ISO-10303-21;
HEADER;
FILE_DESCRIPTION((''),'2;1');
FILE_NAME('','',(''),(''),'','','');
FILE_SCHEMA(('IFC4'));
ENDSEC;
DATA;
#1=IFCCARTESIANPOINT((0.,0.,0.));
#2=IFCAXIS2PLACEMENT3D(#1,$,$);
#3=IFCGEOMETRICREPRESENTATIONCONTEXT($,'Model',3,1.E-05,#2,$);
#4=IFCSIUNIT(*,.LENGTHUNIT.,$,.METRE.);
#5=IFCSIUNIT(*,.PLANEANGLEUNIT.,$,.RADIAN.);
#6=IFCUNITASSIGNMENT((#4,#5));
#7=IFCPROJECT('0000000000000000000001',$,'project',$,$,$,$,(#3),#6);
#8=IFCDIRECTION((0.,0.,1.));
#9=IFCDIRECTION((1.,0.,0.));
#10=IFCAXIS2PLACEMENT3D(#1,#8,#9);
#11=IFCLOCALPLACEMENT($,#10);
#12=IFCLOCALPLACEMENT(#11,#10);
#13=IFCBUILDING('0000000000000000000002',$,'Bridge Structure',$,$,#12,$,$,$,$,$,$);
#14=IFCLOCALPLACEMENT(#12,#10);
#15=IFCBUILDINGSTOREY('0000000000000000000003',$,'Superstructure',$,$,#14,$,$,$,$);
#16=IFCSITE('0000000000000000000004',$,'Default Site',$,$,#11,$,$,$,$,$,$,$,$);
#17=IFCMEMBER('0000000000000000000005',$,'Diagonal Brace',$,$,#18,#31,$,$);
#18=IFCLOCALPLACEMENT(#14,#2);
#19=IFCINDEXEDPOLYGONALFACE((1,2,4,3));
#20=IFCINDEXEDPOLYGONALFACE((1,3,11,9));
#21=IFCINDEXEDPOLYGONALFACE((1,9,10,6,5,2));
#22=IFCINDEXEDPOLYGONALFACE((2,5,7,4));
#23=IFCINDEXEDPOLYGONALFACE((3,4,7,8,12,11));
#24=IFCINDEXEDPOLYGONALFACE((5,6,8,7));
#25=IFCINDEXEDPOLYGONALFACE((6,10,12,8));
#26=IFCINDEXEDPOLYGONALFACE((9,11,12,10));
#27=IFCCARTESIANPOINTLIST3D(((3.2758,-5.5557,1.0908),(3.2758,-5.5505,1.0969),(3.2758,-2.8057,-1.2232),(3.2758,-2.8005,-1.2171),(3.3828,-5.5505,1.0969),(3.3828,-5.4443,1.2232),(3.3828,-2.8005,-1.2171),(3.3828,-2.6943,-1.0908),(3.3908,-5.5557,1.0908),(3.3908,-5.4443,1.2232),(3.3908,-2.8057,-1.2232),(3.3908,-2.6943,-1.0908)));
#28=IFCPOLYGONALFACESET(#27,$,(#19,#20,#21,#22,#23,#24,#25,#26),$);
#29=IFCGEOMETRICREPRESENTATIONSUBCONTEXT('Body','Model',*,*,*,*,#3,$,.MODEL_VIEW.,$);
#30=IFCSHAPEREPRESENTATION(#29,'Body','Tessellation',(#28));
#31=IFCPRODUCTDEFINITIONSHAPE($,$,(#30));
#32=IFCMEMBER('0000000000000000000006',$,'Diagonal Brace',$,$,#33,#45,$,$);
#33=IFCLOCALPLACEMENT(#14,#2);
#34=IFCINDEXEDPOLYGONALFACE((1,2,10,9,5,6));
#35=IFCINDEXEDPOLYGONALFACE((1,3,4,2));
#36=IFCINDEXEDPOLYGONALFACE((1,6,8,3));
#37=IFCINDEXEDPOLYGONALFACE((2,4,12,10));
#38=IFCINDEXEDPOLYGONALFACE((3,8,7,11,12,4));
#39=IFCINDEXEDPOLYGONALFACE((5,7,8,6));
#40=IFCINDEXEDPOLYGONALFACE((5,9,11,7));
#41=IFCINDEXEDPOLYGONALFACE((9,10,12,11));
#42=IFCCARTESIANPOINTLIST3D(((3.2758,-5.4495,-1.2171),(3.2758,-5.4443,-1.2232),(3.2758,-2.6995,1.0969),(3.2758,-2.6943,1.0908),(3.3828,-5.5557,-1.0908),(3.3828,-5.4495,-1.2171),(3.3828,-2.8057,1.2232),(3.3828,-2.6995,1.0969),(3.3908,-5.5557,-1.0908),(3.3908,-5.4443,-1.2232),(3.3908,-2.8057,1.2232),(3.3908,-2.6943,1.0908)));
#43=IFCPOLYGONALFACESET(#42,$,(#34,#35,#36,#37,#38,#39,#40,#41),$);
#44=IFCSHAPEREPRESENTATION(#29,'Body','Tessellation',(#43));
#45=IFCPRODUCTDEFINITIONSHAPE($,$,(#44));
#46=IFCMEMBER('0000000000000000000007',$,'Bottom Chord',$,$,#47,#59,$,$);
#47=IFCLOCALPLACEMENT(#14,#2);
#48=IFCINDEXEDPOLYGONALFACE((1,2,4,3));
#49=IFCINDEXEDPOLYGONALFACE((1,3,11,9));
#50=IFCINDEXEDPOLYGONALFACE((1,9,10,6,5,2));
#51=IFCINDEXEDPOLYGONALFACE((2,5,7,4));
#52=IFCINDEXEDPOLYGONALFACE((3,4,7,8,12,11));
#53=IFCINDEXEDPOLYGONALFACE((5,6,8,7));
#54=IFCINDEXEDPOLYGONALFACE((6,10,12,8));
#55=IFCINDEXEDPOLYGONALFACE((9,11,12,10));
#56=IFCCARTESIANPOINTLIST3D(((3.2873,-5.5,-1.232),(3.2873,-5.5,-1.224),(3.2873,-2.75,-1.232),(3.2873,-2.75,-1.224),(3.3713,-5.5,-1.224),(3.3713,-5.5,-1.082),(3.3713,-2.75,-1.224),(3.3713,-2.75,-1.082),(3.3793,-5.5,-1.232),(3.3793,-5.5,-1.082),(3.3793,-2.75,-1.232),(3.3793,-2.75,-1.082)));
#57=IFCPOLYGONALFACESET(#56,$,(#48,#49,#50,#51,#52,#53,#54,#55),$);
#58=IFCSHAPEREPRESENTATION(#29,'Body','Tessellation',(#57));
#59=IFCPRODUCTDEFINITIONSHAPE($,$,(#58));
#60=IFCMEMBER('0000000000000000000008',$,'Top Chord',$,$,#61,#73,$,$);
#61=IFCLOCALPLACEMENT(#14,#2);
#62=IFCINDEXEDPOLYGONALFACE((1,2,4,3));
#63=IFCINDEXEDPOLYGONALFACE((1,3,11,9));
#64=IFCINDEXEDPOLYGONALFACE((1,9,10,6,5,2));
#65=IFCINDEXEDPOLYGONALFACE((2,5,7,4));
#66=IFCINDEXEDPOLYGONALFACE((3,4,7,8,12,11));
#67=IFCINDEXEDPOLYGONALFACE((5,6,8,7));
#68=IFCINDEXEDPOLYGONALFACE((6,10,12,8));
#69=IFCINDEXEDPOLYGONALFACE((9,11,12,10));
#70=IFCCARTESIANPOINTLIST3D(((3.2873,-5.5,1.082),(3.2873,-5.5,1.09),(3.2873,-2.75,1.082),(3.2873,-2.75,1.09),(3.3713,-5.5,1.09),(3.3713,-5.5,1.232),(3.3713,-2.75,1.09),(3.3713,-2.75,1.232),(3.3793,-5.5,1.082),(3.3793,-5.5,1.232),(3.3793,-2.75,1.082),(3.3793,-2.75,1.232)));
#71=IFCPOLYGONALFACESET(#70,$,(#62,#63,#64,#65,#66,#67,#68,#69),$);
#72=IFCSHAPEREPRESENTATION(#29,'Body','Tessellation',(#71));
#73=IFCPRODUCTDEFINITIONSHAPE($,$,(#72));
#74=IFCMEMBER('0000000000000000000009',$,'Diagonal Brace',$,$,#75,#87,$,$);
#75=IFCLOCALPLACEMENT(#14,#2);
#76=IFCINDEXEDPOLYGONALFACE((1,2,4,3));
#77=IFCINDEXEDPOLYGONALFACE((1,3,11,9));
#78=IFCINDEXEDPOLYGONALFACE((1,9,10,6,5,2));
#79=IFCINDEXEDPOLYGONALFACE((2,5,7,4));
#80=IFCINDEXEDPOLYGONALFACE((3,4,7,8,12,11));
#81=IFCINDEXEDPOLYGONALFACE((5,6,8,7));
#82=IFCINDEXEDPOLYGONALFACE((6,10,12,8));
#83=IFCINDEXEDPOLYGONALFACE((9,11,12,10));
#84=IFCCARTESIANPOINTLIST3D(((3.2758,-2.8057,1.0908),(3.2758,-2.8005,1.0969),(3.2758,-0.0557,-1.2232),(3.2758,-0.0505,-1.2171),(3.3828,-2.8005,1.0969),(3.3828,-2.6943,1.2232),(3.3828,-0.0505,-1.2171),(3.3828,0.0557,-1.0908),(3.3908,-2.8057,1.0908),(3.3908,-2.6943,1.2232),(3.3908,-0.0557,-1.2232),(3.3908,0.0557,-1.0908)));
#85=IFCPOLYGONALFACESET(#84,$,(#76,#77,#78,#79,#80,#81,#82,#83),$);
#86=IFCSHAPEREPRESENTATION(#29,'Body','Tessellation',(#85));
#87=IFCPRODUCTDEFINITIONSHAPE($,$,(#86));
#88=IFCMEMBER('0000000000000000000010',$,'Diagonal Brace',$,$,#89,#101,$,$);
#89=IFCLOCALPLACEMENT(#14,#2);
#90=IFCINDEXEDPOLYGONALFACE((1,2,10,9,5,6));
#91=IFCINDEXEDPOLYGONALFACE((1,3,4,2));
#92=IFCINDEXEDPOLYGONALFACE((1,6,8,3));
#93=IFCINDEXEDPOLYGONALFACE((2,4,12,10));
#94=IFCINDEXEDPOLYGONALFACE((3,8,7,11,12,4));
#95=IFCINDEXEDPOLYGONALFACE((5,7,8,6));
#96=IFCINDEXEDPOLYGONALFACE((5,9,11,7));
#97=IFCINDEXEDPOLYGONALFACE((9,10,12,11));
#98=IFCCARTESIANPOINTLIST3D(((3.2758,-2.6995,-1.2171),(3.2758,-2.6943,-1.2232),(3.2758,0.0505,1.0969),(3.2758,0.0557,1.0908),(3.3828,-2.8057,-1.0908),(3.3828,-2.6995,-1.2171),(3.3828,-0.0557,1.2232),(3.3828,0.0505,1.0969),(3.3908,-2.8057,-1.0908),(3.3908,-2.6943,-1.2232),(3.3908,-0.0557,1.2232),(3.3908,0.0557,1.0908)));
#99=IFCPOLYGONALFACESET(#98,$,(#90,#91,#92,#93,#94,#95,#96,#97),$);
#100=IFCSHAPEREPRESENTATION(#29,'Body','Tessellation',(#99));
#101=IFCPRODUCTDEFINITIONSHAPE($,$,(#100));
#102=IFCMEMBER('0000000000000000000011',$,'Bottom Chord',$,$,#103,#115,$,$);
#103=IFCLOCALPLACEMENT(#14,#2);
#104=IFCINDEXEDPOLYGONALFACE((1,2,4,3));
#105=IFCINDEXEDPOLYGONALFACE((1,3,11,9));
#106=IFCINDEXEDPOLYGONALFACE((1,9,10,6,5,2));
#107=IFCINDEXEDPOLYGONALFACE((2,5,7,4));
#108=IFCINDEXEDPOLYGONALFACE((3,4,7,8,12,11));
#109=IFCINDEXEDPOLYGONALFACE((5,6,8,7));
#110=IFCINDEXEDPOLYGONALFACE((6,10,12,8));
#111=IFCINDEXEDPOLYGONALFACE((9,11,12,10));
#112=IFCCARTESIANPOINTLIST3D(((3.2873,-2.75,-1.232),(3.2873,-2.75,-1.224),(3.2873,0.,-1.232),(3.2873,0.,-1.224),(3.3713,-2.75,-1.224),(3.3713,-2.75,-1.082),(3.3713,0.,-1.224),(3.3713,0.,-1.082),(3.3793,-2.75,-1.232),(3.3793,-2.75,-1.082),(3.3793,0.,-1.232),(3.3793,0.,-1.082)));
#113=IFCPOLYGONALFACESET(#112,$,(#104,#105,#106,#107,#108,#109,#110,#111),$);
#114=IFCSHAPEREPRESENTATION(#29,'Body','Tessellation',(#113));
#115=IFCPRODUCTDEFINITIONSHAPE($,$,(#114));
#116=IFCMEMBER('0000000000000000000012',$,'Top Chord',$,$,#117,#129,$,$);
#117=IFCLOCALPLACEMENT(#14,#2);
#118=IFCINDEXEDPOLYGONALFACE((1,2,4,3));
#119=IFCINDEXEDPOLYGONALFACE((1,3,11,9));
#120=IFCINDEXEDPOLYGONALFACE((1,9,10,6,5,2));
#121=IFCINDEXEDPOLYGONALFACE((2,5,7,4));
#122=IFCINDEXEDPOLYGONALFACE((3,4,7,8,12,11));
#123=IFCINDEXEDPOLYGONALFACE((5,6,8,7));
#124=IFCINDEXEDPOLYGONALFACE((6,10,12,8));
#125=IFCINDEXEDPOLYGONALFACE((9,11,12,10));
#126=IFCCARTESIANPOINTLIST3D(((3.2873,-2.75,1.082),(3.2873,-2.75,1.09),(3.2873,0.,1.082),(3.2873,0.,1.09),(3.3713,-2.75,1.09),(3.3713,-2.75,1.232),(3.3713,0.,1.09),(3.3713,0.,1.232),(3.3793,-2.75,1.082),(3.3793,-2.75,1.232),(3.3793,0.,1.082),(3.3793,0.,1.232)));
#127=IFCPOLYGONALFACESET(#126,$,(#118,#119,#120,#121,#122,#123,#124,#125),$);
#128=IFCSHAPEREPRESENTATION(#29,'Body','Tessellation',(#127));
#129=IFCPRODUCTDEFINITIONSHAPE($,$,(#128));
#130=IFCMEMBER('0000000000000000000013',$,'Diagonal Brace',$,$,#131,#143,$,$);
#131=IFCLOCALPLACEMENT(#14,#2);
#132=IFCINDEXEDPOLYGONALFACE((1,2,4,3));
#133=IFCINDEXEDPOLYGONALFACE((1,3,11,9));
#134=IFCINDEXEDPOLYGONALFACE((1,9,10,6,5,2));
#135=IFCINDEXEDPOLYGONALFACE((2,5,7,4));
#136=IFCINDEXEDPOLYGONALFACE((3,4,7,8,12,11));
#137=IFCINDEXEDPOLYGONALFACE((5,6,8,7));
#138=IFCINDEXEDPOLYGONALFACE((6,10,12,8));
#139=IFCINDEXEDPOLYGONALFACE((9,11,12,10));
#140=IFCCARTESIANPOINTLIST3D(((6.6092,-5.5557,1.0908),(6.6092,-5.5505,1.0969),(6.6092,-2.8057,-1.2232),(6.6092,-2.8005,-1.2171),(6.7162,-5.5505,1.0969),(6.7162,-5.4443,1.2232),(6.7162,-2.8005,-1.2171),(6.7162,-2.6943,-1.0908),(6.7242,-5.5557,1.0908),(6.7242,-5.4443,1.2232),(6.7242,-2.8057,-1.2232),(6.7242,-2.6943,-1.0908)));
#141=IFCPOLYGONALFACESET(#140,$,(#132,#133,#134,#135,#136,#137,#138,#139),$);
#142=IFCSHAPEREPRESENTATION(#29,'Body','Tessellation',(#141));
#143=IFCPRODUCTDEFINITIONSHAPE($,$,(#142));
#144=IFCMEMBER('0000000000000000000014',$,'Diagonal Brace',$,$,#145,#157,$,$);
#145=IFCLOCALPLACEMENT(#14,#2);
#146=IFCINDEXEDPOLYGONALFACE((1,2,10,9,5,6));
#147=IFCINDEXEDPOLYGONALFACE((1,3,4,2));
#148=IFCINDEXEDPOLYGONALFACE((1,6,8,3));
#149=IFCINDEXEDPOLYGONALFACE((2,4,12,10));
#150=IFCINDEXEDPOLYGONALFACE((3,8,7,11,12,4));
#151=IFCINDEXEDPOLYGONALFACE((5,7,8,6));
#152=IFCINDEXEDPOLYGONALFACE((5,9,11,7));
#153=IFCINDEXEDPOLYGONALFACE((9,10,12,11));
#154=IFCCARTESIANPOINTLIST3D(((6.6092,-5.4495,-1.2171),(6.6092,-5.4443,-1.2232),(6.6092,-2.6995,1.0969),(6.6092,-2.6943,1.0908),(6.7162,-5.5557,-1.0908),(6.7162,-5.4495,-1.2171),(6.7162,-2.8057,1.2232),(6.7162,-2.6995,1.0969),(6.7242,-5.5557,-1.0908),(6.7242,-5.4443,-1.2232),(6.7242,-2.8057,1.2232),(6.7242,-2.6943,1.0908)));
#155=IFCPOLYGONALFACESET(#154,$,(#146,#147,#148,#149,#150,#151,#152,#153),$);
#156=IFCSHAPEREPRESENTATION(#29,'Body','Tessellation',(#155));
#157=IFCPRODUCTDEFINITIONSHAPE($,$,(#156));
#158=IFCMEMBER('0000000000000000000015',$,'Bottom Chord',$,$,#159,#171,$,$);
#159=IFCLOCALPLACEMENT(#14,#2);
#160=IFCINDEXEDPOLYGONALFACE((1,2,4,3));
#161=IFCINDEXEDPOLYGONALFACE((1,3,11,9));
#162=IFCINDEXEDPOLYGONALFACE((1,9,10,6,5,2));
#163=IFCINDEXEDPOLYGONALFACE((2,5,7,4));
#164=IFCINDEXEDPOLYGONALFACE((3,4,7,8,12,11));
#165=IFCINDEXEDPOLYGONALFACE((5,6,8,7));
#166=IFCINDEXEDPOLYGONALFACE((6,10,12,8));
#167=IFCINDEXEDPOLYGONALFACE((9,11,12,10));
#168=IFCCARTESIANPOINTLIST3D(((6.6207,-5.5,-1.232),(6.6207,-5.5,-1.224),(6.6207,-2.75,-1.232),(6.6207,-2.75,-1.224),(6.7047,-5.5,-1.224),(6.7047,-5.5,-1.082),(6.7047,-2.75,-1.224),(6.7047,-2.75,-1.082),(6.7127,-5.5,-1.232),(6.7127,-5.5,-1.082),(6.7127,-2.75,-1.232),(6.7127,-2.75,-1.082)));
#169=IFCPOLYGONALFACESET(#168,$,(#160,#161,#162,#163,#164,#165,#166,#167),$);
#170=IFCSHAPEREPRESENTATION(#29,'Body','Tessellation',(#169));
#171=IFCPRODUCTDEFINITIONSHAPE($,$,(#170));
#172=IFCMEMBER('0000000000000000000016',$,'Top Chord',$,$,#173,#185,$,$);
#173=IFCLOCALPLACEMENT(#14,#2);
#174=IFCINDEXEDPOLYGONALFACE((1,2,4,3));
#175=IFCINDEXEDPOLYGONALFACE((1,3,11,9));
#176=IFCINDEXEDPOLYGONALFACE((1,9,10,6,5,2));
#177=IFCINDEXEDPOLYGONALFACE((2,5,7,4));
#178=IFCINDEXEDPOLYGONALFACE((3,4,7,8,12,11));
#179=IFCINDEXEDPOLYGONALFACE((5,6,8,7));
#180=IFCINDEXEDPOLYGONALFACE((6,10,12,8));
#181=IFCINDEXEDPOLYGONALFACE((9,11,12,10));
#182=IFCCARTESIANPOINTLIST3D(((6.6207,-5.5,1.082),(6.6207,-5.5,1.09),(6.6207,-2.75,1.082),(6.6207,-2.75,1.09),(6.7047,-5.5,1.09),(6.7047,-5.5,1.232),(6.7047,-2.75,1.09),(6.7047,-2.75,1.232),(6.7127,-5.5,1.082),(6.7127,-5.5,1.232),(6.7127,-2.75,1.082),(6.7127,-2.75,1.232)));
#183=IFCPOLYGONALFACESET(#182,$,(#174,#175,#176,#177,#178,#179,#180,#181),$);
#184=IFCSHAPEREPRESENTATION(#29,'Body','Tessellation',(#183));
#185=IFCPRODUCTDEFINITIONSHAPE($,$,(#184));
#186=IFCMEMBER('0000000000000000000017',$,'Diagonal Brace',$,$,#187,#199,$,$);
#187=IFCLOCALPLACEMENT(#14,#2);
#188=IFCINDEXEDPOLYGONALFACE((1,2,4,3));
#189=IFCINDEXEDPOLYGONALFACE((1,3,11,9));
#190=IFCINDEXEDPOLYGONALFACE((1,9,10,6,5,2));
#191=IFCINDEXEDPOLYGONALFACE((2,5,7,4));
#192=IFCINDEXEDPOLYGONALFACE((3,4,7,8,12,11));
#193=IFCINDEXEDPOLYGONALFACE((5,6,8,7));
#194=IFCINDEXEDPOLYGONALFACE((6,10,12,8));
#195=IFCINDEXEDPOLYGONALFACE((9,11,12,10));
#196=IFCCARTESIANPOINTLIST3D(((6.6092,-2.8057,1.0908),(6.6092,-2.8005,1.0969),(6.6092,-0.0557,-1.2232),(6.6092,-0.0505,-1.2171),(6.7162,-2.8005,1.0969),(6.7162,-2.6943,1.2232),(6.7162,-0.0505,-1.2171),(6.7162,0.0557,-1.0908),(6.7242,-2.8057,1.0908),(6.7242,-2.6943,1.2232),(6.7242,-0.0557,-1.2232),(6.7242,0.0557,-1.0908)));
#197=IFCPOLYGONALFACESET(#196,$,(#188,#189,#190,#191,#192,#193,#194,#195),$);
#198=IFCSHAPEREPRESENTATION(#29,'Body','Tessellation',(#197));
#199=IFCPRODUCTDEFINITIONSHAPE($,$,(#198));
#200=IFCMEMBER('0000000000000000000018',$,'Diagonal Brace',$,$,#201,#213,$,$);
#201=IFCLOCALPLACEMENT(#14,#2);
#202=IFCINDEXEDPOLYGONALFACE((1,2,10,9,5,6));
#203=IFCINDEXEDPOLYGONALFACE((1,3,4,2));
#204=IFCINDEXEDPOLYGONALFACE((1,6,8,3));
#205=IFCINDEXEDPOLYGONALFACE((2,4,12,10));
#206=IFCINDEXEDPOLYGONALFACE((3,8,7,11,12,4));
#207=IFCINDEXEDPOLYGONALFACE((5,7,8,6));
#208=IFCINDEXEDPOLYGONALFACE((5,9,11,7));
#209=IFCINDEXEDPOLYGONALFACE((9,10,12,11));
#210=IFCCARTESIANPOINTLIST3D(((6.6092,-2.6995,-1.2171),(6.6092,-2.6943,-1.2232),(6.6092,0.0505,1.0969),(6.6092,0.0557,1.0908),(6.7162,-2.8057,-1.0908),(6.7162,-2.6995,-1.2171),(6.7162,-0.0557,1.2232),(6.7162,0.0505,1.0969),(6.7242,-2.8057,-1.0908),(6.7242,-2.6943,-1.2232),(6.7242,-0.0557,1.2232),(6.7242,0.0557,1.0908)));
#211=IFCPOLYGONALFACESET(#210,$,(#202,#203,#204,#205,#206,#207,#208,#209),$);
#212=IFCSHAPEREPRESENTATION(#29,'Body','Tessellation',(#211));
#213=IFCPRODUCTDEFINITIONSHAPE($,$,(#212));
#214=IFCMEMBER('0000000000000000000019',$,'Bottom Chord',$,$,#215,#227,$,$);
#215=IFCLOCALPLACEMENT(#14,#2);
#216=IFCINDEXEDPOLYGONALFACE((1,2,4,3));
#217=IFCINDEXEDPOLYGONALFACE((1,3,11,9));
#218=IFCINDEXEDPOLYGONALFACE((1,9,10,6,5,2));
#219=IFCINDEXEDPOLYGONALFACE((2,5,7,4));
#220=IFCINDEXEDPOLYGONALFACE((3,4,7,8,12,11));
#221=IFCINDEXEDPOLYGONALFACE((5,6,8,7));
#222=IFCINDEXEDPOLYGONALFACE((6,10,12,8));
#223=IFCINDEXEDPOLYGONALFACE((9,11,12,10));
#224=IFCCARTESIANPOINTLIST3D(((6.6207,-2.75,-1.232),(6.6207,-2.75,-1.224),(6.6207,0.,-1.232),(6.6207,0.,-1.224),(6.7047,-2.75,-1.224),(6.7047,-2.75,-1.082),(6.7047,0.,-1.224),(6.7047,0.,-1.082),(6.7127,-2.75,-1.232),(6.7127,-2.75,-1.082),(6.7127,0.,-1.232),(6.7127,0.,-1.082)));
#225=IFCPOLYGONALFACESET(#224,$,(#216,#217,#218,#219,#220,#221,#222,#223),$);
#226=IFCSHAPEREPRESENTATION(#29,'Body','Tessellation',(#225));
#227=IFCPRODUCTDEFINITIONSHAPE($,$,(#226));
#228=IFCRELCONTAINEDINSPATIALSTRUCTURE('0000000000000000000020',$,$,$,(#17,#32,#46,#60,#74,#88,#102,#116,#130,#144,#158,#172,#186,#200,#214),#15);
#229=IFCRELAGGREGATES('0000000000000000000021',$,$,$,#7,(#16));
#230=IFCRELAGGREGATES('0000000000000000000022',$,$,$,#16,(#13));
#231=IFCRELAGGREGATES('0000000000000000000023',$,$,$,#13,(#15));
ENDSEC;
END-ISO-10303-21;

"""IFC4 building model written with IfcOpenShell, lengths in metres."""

from ifc_helpers import new_model, si_unit, frame, origin, origin_with_axes, origin_2d_with_axis, place, context, subcontext, project, spatial, l_section, extrude, element, save


model = new_model("IFC4")

# Units and contexts
model_context = context("Model", 3, precision=1e-05, world=origin())
body_context = subcontext(model_context, "Body", "Model", "MODEL_VIEW")
ifc_project = project(units=[si_unit("LENGTHUNIT", "METRE"), si_unit("PLANEANGLEUNIT", "RADIAN")], contexts=[model_context])

# Site, building, storey
site_placement = place(None, origin_with_axes())
site = spatial("IfcSite", under=ifc_project, at=site_placement, Name="Default Site")
building_placement = place(site_placement, origin_with_axes())
building = spatial("IfcBuilding", under=site, at=building_placement, Name="Bridge Structure")
storey_placement = place(building_placement, origin_with_axes())
storey = spatial("IfcBuildingStorey", under=building, at=storey_placement, Name="Superstructure")

# Members
for number, where, z_axis, x_axis, name in (
    (1, (3.3333, -5.5, 1.157), (0.0, 0.765156, -0.643844), (-1.0, 0.0, 0.0), "Diagonal Brace"),
    (2, (3.3333, -5.5, -1.157), (0.0, 0.765156, 0.643844), (-1.0, 0.0, 0.0), "Diagonal Brace"),
):
    element("IfcMember", number, at=place(storey_placement, frame(where, z_axis=z_axis, x_axis=x_axis)), inside=storey, Name=name, context=body_context, shape_type="SweptSolid", body=[
        extrude(l_section(Depth=0.173, Width=0.115, Thickness=0.008, at=origin_2d_with_axis()), origin_with_axes(), (0.0, 0.0, 1.0), 3.594),
    ])
for number, where, z_axis, x_axis, name in (
    (3, (3.3333, -5.5, -1.157), (0.0, 1.0, 0.0), (-1.0, 0.0, 0.0), "Bottom Chord"),
    (4, (3.3333, -5.5, 1.157), (0.0, 1.0, 0.0), (-1.0, 0.0, 0.0), "Top Chord"),
):
    element("IfcMember", number, at=place(storey_placement, frame(where, z_axis=z_axis, x_axis=x_axis)), inside=storey, Name=name, context=body_context, shape_type="SweptSolid", body=[
        extrude(l_section(Depth=0.15, Width=0.092, Thickness=0.008, at=origin_2d_with_axis()), origin_with_axes(), (0.0, 0.0, 1.0), 2.75),
    ])
for number, where, z_axis, x_axis, name in (
    (5, (3.3333, -2.75, 1.157), (0.0, 0.765156, -0.643844), (-1.0, 0.0, 0.0), "Diagonal Brace"),
    (6, (3.3333, -2.75, -1.157), (0.0, 0.765156, 0.643844), (-1.0, 0.0, 0.0), "Diagonal Brace"),
):
    element("IfcMember", number, at=place(storey_placement, frame(where, z_axis=z_axis, x_axis=x_axis)), inside=storey, Name=name, context=body_context, shape_type="SweptSolid", body=[
        extrude(l_section(Depth=0.173, Width=0.115, Thickness=0.008, at=origin_2d_with_axis()), origin_with_axes(), (0.0, 0.0, 1.0), 3.594),
    ])
for number, where, z_axis, x_axis, name in (
    (7, (3.3333, -2.75, -1.157), (0.0, 1.0, 0.0), (-1.0, 0.0, 0.0), "Bottom Chord"),
    (8, (3.3333, -2.75, 1.157), (0.0, 1.0, 0.0), (-1.0, 0.0, 0.0), "Top Chord"),
):
    element("IfcMember", number, at=place(storey_placement, frame(where, z_axis=z_axis, x_axis=x_axis)), inside=storey, Name=name, context=body_context, shape_type="SweptSolid", body=[
        extrude(l_section(Depth=0.15, Width=0.092, Thickness=0.008, at=origin_2d_with_axis()), origin_with_axes(), (0.0, 0.0, 1.0), 2.75),
    ])
for number, where, z_axis, x_axis, name in (
    (9, (6.6667, -5.5, 1.157), (0.0, 0.765156, -0.643844), (-1.0, 0.0, 0.0), "Diagonal Brace"),
    (10, (6.6667, -5.5, -1.157), (0.0, 0.765156, 0.643844), (-1.0, 0.0, 0.0), "Diagonal Brace"),
):
    element("IfcMember", number, at=place(storey_placement, frame(where, z_axis=z_axis, x_axis=x_axis)), inside=storey, Name=name, context=body_context, shape_type="SweptSolid", body=[
        extrude(l_section(Depth=0.173, Width=0.115, Thickness=0.008, at=origin_2d_with_axis()), origin_with_axes(), (0.0, 0.0, 1.0), 3.594),
    ])
for number, where, z_axis, x_axis, name in (
    (11, (6.6667, -5.5, -1.157), (0.0, 1.0, 0.0), (-1.0, 0.0, 0.0), "Bottom Chord"),
    (12, (6.6667, -5.5, 1.157), (0.0, 1.0, 0.0), (-1.0, 0.0, 0.0), "Top Chord"),
):
    element("IfcMember", number, at=place(storey_placement, frame(where, z_axis=z_axis, x_axis=x_axis)), inside=storey, Name=name, context=body_context, shape_type="SweptSolid", body=[
        extrude(l_section(Depth=0.15, Width=0.092, Thickness=0.008, at=origin_2d_with_axis()), origin_with_axes(), (0.0, 0.0, 1.0), 2.75),
    ])
for number, where, z_axis, x_axis, name in (
    (13, (6.6667, -2.75, 1.157), (0.0, 0.765156, -0.643844), (-1.0, 0.0, 0.0), "Diagonal Brace"),
    (14, (6.6667, -2.75, -1.157), (0.0, 0.765156, 0.643844), (-1.0, 0.0, 0.0), "Diagonal Brace"),
):
    element("IfcMember", number, at=place(storey_placement, frame(where, z_axis=z_axis, x_axis=x_axis)), inside=storey, Name=name, context=body_context, shape_type="SweptSolid", body=[
        extrude(l_section(Depth=0.173, Width=0.115, Thickness=0.008, at=origin_2d_with_axis()), origin_with_axes(), (0.0, 0.0, 1.0), 3.594),
    ])
for number, where, z_axis, x_axis, name in (
    (15, (6.6667, -2.75, -1.157), (0.0, 1.0, 0.0), (-1.0, 0.0, 0.0), "Bottom Chord"),
):
    element("IfcMember", number, at=place(storey_placement, frame(where, z_axis=z_axis, x_axis=x_axis)), inside=storey, Name=name, context=body_context, shape_type="SweptSolid", body=[
        extrude(l_section(Depth=0.15, Width=0.092, Thickness=0.008, at=origin_2d_with_axis()), origin_with_axes(), (0.0, 0.0, 1.0), 2.75),
    ])

save(model, "model.ifc")
